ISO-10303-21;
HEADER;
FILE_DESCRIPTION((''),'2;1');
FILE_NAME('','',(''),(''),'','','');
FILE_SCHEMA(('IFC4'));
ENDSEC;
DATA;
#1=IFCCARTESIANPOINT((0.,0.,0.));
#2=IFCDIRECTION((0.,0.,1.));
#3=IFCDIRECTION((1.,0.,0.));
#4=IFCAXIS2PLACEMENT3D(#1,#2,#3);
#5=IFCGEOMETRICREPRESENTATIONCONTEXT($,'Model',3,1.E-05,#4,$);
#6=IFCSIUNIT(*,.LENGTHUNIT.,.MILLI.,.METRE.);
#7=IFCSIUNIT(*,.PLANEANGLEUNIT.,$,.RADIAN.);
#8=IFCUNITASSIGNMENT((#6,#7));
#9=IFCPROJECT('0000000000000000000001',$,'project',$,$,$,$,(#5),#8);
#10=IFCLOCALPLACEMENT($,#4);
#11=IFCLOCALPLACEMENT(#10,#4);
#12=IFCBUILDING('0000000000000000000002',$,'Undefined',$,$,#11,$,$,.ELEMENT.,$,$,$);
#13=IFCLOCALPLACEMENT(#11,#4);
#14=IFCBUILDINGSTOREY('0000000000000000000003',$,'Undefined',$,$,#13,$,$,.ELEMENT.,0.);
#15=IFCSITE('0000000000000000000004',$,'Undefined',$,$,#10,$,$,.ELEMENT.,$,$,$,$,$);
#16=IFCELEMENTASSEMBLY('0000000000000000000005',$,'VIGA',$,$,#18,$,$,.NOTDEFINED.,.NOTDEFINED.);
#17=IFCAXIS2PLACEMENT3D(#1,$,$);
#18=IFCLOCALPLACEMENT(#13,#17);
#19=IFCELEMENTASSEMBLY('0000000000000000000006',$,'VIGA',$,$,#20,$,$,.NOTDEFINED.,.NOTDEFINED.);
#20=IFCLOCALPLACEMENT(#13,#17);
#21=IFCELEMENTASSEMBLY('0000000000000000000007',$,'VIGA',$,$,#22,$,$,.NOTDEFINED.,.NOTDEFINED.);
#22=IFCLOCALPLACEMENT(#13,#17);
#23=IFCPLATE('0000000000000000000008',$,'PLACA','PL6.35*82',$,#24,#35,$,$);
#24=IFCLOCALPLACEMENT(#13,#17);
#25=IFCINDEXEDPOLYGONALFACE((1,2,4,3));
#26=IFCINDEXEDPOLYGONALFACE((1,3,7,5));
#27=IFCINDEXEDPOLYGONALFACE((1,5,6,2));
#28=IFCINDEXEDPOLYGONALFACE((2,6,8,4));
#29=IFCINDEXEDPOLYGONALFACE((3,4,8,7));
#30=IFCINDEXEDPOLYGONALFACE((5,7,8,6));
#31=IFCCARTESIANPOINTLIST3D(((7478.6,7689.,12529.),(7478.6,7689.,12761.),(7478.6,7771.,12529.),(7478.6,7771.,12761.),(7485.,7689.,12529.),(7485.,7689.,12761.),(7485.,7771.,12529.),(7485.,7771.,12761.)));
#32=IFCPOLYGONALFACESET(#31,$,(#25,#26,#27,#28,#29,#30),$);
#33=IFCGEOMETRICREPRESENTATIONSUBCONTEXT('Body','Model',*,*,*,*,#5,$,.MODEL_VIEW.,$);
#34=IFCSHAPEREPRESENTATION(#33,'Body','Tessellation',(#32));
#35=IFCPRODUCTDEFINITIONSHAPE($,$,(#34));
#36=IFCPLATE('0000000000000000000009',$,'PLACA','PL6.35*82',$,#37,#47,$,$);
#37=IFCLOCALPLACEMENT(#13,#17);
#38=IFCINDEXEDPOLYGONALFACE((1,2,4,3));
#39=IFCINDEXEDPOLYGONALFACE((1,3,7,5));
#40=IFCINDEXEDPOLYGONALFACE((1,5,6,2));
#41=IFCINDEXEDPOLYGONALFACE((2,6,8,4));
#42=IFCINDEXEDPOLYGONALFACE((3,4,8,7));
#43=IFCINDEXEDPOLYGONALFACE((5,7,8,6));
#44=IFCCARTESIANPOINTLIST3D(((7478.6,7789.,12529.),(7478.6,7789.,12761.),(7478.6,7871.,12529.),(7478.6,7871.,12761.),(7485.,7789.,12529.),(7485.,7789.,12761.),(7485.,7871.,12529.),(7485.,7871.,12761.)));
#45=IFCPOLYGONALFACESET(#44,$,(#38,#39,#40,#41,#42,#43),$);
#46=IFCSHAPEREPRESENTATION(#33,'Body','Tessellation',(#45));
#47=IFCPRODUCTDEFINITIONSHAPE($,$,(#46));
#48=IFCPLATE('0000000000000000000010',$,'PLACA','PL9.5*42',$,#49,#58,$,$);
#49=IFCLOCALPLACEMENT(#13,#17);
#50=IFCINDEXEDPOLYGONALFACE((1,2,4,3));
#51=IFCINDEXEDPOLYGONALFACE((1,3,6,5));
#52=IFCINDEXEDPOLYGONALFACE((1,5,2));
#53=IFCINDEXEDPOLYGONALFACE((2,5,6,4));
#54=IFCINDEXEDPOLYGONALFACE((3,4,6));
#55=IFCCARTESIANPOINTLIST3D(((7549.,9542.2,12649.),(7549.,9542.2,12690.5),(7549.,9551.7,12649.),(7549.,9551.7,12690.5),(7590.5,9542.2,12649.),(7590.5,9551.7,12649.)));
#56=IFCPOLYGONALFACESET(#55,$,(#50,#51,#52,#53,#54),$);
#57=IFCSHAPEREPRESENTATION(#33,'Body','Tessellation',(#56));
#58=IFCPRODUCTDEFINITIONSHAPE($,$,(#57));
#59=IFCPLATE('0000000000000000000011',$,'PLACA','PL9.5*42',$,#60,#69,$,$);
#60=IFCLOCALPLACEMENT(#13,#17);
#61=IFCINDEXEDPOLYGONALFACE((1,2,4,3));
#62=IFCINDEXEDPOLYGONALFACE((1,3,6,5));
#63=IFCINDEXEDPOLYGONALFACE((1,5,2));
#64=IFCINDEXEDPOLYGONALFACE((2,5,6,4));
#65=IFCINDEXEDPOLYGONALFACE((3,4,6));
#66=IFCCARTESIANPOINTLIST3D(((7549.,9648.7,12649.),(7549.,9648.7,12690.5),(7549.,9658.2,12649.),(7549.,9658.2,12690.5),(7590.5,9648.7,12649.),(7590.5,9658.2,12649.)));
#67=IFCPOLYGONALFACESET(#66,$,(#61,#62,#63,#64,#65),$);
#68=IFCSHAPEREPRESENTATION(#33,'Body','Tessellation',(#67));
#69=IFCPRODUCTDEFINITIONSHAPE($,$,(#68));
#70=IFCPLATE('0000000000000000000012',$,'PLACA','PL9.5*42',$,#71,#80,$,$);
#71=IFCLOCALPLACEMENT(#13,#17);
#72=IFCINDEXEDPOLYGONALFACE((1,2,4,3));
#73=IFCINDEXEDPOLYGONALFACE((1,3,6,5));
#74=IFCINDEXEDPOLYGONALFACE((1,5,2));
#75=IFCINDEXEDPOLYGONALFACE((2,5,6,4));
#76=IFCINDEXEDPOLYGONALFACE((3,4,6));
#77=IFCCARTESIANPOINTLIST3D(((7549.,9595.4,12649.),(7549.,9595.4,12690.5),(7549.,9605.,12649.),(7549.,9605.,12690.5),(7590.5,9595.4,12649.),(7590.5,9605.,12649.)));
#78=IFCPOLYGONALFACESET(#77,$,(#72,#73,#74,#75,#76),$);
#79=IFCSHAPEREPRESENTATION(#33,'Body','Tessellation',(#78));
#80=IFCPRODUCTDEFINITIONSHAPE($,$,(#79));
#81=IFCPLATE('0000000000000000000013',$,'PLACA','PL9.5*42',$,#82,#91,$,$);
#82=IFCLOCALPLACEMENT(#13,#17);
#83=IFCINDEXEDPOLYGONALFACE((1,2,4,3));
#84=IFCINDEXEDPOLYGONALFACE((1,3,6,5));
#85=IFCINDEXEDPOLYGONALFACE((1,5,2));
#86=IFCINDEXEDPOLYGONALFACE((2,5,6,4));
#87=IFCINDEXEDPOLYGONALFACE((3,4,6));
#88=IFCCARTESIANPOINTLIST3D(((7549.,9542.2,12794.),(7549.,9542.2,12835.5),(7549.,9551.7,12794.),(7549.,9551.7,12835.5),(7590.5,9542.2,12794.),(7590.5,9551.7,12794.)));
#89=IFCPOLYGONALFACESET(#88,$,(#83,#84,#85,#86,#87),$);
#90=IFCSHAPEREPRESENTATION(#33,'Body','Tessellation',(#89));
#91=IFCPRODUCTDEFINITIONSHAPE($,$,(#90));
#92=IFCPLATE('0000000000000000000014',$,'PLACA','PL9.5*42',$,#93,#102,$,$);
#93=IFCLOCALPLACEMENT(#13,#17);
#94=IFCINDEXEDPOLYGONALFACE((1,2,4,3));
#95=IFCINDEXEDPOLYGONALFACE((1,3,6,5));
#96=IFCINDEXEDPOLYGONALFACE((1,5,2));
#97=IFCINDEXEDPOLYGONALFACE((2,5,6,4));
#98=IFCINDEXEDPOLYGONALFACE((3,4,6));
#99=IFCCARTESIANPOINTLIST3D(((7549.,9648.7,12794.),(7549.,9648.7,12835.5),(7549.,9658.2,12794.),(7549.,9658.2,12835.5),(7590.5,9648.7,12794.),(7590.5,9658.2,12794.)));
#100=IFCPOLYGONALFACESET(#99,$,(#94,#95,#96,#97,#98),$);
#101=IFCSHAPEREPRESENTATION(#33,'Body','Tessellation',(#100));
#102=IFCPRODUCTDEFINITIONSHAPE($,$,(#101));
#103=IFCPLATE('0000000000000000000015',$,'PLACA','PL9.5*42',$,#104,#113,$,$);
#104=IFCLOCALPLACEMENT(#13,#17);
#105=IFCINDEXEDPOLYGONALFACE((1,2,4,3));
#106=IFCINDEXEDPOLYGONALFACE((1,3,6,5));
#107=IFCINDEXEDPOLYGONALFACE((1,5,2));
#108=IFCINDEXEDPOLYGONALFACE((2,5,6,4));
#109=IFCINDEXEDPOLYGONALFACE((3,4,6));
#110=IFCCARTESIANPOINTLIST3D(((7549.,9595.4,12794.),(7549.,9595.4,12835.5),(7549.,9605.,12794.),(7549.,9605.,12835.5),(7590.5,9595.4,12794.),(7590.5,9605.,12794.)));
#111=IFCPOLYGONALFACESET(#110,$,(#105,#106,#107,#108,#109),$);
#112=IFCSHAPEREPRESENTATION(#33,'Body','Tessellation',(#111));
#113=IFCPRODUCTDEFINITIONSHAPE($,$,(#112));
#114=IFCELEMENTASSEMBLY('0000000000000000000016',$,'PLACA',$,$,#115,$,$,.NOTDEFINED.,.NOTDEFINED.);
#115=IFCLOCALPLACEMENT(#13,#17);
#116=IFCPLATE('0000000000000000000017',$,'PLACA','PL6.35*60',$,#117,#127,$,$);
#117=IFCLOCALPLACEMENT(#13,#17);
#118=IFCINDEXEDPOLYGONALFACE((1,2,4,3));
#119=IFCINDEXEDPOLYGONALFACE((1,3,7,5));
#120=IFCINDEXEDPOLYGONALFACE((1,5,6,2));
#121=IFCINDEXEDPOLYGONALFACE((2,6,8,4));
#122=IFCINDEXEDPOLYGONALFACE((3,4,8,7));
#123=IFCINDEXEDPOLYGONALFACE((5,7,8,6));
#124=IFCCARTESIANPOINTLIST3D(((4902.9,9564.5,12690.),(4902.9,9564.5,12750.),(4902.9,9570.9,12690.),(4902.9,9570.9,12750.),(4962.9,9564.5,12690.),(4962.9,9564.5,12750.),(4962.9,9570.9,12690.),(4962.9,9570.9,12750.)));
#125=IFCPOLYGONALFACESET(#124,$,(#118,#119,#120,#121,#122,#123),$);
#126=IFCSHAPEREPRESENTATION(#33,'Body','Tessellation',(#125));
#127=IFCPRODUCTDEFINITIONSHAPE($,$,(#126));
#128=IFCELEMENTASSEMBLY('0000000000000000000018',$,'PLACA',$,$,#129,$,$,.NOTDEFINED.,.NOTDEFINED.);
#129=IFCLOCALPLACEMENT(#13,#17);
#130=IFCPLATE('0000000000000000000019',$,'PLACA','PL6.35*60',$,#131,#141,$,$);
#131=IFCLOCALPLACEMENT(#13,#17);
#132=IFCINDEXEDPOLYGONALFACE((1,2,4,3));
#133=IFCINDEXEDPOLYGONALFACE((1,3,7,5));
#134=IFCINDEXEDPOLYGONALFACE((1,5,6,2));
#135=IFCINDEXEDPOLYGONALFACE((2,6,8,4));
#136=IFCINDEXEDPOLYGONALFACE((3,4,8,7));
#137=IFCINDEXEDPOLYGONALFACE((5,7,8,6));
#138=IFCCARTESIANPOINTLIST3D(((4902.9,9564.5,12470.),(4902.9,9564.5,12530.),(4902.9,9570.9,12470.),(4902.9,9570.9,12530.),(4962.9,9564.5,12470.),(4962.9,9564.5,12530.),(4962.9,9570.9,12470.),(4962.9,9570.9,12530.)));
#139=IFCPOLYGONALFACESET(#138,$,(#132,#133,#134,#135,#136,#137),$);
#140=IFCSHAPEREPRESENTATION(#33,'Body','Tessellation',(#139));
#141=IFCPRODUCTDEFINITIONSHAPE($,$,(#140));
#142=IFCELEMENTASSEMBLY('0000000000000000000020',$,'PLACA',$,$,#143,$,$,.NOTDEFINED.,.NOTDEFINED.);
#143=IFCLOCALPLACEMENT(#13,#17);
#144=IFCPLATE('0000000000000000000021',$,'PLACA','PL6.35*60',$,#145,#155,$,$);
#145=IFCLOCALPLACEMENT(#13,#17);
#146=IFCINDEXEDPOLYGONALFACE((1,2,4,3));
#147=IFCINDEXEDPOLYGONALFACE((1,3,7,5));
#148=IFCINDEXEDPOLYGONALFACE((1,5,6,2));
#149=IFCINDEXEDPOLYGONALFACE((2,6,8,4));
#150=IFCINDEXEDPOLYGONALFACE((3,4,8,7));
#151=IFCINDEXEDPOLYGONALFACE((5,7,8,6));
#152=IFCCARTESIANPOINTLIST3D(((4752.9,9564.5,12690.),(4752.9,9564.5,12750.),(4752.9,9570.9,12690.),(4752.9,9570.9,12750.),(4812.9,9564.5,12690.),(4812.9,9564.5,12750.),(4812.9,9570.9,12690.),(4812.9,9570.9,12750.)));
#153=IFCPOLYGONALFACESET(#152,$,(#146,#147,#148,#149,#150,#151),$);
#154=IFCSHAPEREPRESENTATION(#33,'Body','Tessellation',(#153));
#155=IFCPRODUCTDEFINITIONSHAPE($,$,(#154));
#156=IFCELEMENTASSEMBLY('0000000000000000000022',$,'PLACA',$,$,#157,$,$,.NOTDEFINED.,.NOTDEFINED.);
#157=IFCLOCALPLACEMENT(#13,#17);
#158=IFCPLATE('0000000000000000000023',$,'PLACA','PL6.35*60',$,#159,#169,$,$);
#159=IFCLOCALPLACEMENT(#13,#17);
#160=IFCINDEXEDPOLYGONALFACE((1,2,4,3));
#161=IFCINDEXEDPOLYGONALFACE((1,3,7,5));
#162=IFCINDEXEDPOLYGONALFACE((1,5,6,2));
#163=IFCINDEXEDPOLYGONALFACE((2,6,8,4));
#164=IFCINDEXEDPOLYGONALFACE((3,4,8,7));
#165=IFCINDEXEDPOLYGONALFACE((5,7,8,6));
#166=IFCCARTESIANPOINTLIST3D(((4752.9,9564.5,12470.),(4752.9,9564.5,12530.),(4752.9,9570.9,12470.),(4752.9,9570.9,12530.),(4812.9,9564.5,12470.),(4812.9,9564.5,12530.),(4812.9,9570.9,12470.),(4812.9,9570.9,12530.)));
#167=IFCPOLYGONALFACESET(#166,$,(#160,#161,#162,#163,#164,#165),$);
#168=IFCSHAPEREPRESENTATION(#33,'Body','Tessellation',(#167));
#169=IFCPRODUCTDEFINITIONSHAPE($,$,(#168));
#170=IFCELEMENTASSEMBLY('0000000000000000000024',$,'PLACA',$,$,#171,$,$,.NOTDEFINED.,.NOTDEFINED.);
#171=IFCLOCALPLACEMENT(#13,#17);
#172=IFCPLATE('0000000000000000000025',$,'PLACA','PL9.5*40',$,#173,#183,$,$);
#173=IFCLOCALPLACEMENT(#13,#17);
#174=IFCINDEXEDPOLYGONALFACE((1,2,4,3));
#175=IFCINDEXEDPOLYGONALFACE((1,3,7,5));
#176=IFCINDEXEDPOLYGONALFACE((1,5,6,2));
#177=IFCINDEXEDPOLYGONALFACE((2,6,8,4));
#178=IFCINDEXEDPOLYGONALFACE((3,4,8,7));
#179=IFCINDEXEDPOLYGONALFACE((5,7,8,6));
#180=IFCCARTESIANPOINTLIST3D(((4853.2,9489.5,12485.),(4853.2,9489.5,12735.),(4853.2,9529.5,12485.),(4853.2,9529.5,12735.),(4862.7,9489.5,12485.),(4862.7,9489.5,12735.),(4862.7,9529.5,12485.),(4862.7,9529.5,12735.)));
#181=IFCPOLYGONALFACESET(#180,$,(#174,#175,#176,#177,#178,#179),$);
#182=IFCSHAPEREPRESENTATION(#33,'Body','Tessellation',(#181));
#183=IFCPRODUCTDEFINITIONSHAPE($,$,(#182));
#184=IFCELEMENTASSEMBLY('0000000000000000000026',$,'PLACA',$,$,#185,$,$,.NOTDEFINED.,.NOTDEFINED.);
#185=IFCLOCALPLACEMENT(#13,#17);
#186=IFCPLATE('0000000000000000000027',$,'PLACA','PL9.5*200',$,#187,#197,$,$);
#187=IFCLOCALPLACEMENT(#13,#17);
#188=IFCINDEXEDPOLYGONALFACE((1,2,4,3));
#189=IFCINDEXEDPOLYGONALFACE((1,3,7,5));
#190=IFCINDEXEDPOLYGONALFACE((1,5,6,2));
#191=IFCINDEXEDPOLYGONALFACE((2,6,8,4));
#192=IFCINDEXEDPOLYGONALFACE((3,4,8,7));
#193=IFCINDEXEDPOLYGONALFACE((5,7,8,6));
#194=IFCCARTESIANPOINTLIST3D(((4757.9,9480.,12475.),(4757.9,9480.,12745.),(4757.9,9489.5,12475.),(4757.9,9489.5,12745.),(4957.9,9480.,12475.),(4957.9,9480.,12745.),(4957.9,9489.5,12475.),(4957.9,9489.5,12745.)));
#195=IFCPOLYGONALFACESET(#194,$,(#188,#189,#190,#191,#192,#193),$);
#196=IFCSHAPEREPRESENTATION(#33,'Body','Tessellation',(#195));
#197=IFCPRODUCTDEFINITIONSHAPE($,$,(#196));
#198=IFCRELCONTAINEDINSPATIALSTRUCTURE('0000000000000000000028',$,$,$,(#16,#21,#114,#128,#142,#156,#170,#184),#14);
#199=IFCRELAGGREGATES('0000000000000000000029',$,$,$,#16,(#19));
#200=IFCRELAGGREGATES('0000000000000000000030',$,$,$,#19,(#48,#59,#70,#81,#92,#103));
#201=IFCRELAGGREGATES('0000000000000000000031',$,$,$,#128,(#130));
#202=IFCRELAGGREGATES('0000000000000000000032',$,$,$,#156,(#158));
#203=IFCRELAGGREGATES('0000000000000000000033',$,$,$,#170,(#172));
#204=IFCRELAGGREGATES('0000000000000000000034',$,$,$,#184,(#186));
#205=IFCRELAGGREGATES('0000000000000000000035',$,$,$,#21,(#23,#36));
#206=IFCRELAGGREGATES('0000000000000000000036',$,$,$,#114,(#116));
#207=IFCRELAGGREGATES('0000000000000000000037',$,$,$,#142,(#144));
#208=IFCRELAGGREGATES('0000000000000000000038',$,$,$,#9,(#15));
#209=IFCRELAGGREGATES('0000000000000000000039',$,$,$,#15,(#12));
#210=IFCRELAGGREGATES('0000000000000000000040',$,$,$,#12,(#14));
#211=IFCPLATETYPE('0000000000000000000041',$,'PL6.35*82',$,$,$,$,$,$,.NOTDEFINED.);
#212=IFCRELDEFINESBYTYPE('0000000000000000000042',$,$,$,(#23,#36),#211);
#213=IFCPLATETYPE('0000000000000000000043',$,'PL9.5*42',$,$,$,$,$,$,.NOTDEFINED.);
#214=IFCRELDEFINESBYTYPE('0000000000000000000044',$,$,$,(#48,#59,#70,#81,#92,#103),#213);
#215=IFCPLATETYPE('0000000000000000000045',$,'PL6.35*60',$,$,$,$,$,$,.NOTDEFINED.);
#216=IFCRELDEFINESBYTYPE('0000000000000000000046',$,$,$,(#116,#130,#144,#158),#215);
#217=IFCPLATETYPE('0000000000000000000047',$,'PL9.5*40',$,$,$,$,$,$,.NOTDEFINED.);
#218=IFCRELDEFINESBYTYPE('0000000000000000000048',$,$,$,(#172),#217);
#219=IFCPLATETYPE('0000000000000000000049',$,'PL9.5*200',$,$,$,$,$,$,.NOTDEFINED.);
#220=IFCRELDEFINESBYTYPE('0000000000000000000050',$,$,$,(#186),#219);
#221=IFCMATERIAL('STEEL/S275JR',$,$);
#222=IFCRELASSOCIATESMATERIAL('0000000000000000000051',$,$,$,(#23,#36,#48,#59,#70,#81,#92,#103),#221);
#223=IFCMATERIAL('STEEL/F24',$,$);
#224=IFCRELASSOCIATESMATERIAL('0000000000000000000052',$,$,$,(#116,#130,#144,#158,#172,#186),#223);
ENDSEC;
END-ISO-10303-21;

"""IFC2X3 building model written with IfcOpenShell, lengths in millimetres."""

from ifc_helpers import new_model, si_unit, frame, origin_with_axes, place, context, subcontext, project, spatial, polyline, outline, extrude, material, type_object, element, aggregate, save


model = new_model("IFC2X3")

# Units and contexts
model_context = context("Model", 3, precision=1e-05, world=origin_with_axes())
body_context = subcontext(model_context, "Body", "Model", "MODEL_VIEW")
ifc_project = project(units=[si_unit("LENGTHUNIT", "METRE", prefix="MILLI"), si_unit("PLANEANGLEUNIT", "RADIAN")], contexts=[model_context])

# Site, building, storey
site_placement = place(None, origin_with_axes())
site = spatial("IfcSite", under=ifc_project, at=site_placement, Name="Undefined", CompositionType="ELEMENT")
building_placement = place(site_placement, origin_with_axes())
building = spatial("IfcBuilding", under=site, at=building_placement, Name="Undefined", CompositionType="ELEMENT")
storey_placement = place(building_placement, origin_with_axes())
storey = spatial("IfcBuildingStorey", under=building, at=storey_placement, Name="Undefined", CompositionType="ELEMENT", Elevation=0.0)

# Shared definitions
ifc_material_1 = material(Name="STEEL/S275JR")

# Element assemblies
assembly_1_placement = place(storey_placement, origin_with_axes())
assembly_1 = element("IfcElementAssembly", 1, at=assembly_1_placement, inside=storey, Name="VIGA", AssemblyPlace="NOTDEFINED", PredefinedType="NOTDEFINED")
assembly_2_placement = place(assembly_1_placement, origin_with_axes())
assembly_2 = element("IfcElementAssembly", 2, at=assembly_2_placement, Name="VIGA", AssemblyPlace="NOTDEFINED", PredefinedType="NOTDEFINED")
aggregate(assembly_1, [assembly_2])

# Element assembly, plates
assembly_3_placement = place(storey_placement, origin_with_axes())
assembly_3 = element("IfcElementAssembly", 3, at=assembly_3_placement, inside=storey, Name="VIGA", AssemblyPlace="NOTDEFINED", PredefinedType="NOTDEFINED")
plate_type_1 = type_object("IfcPlateType", Name="PL6.35*82", PredefinedType="NOTDEFINED")
plate_1_placement = place(assembly_3_placement, frame((7481.8, 7689.0, 12761.0), z_axis=(-1.0, 0.0, 0.0), x_axis=(0.0, 1.0, 0.0)))
plate_1 = element("IfcPlate", 4, at=plate_1_placement, type_object=plate_type_1, material=ifc_material_1, Name="PLACA", Description="PL6.35*82", context=body_context, shape_type="SweptSolid", body=[
    extrude(outline(polyline([(0.0, 0.0), (82.0, 0.0), (82.0, 232.0), (0.0, 232.0), (0.0, 0.0)])), frame((0.0, 0.0, -3.2), z_axis=(0.0, 0.0, 1.0), x_axis=(1.0, 0.0, 0.0)), (0.0, 0.0, 1.0), 6.4),
])
plate_2_placement = place(assembly_3_placement, frame((7481.8, 7789.0, 12761.0), z_axis=(-1.0, 0.0, 0.0), x_axis=(0.0, 1.0, 0.0)))
plate_2 = element("IfcPlate", 5, at=plate_2_placement, type_object=plate_type_1, material=ifc_material_1, Name="PLACA", Description="PL6.35*82", context=body_context, shape_type="SweptSolid", body=[
    extrude(outline(polyline([(0.0, 0.0), (82.0, 0.0), (82.0, 232.0), (0.0, 232.0), (0.0, 0.0)])), frame((0.0, 0.0, -3.2), z_axis=(0.0, 0.0, 1.0), x_axis=(1.0, 0.0, 0.0)), (0.0, 0.0, 1.0), 6.4),
])

# Plates
plate_type_2 = type_object("IfcPlateType", Name="PL9.5*42", PredefinedType="NOTDEFINED")
plate_3_placement = place(assembly_2_placement, frame((7549.0, 9547.0, 12649.0), z_axis=(0.0, 1.0, 0.0), x_axis=(0.0, 0.0, 1.0)))
plate_3 = element("IfcPlate", 6, at=plate_3_placement, type_object=plate_type_2, material=ifc_material_1, Name="PLACA", Description="PL9.5*42", context=body_context, shape_type="SweptSolid", body=[
    extrude(outline(polyline([(0.0, 0.0), (41.5, 0.0), (0.0, 41.5), (0.0, 0.0)])), frame((0.0, 0.0, -4.7), z_axis=(0.0, 0.0, 1.0), x_axis=(1.0, 0.0, 0.0)), (0.0, 0.0, 1.0), 9.5),
])
plate_4_placement = place(assembly_2_placement, frame((7549.0, 9653.5, 12649.0), z_axis=(0.0, 1.0, 0.0), x_axis=(0.0, 0.0, 1.0)))
plate_4 = element("IfcPlate", 7, at=plate_4_placement, type_object=plate_type_2, material=ifc_material_1, Name="PLACA", Description="PL9.5*42", context=body_context, shape_type="SweptSolid", body=[
    extrude(outline(polyline([(0.0, 0.0), (41.5, 0.0), (0.0, 41.5), (0.0, 0.0)])), frame((0.0, 0.0, -4.7), z_axis=(0.0, 0.0, 1.0), x_axis=(1.0, 0.0, 0.0)), (0.0, 0.0, 1.0), 9.5),
])
plate_5_placement = place(assembly_2_placement, frame((7549.0, 9600.2, 12649.0), z_axis=(0.0, 1.0, 0.0), x_axis=(0.0, 0.0, 1.0)))
plate_5 = element("IfcPlate", 8, at=plate_5_placement, type_object=plate_type_2, material=ifc_material_1, Name="PLACA", Description="PL9.5*42", context=body_context, shape_type="SweptSolid", body=[
    extrude(outline(polyline([(0.0, 0.0), (41.5, 0.0), (0.0, 41.5), (0.0, 0.0)])), frame((0.0, 0.0, -4.7), z_axis=(0.0, 0.0, 1.0), x_axis=(1.0, 0.0, 0.0)), (0.0, 0.0, 1.0), 9.5),
])
plate_6_placement = place(assembly_2_placement, frame((7549.0, 9547.0, 12794.0), z_axis=(0.0, 1.0, 0.0), x_axis=(0.0, 0.0, 1.0)))
plate_6 = element("IfcPlate", 9, at=plate_6_placement, type_object=plate_type_2, material=ifc_material_1, Name="PLACA", Description="PL9.5*42", context=body_context, shape_type="SweptSolid", body=[
    extrude(outline(polyline([(0.0, 0.0), (41.5, 0.0), (0.0, 41.5), (0.0, 0.0)])), frame((0.0, 0.0, -4.7), z_axis=(0.0, 0.0, 1.0), x_axis=(1.0, 0.0, 0.0)), (0.0, 0.0, 1.0), 9.5),
])
plate_7_placement = place(assembly_2_placement, frame((7549.0, 9653.5, 12794.0), z_axis=(0.0, 1.0, 0.0), x_axis=(0.0, 0.0, 1.0)))
plate_7 = element("IfcPlate", 10, at=plate_7_placement, type_object=plate_type_2, material=ifc_material_1, Name="PLACA", Description="PL9.5*42", context=body_context, shape_type="SweptSolid", body=[
    extrude(outline(polyline([(0.0, 0.0), (41.5, 0.0), (0.0, 41.5), (0.0, 0.0)])), frame((0.0, 0.0, -4.7), z_axis=(0.0, 0.0, 1.0), x_axis=(1.0, 0.0, 0.0)), (0.0, 0.0, 1.0), 9.5),
])
plate_8_placement = place(assembly_2_placement, frame((7549.0, 9600.2, 12794.0), z_axis=(0.0, 1.0, 0.0), x_axis=(0.0, 0.0, 1.0)))
plate_8 = element("IfcPlate", 11, at=plate_8_placement, type_object=plate_type_2, material=ifc_material_1, Name="PLACA", Description="PL9.5*42", context=body_context, shape_type="SweptSolid", body=[
    extrude(outline(polyline([(0.0, 0.0), (41.5, 0.0), (0.0, 41.5), (0.0, 0.0)])), frame((0.0, 0.0, -4.7), z_axis=(0.0, 0.0, 1.0), x_axis=(1.0, 0.0, 0.0)), (0.0, 0.0, 1.0), 9.5),
])
aggregate(assembly_2, [plate_3, plate_4, plate_5, plate_6, plate_7, plate_8])

# Element assemblies, plates
assembly_4_placement = place(storey_placement, origin_with_axes())
assembly_4 = element("IfcElementAssembly", 12, at=assembly_4_placement, inside=storey, Name="PLACA", AssemblyPlace="NOTDEFINED", PredefinedType="NOTDEFINED")
ifc_material_2 = material(Name="STEEL/F24")
plate_type_3 = type_object("IfcPlateType", Name="PL6.35*60", PredefinedType="NOTDEFINED")
plate_9_placement = place(assembly_4_placement, frame((4902.9, 9567.7, 12750.0), z_axis=(0.0, 1.0, 0.0), x_axis=(1.0, 0.0, 0.0)))
plate_9 = element("IfcPlate", 13, at=plate_9_placement, type_object=plate_type_3, material=ifc_material_2, Name="PLACA", Description="PL6.35*60", context=body_context, shape_type="SweptSolid", body=[
    extrude(outline(polyline([(0.0, 0.0), (60.0, 0.0), (60.0, 60.0), (0.0, 60.0), (0.0, 0.0)])), frame((0.0, 0.0, -3.2), z_axis=(0.0, 0.0, 1.0), x_axis=(1.0, 0.0, 0.0)), (0.0, 0.0, 1.0), 6.4),
])
assembly_5_placement = place(storey_placement, origin_with_axes())
assembly_5 = element("IfcElementAssembly", 14, at=assembly_5_placement, inside=storey, Name="PLACA", AssemblyPlace="NOTDEFINED", PredefinedType="NOTDEFINED")
plate_10_placement = place(assembly_5_placement, frame((4902.9, 9567.7, 12530.0), z_axis=(0.0, 1.0, 0.0), x_axis=(1.0, 0.0, 0.0)))
plate_10 = element("IfcPlate", 15, at=plate_10_placement, type_object=plate_type_3, material=ifc_material_2, Name="PLACA", Description="PL6.35*60", context=body_context, shape_type="SweptSolid", body=[
    extrude(outline(polyline([(0.0, 0.0), (60.0, 0.0), (60.0, 60.0), (0.0, 60.0), (0.0, 0.0)])), frame((0.0, 0.0, -3.2), z_axis=(0.0, 0.0, 1.0), x_axis=(1.0, 0.0, 0.0)), (0.0, 0.0, 1.0), 6.4),
])
aggregate(assembly_5, [plate_10])
assembly_6_placement = place(storey_placement, origin_with_axes())
assembly_6 = element("IfcElementAssembly", 16, at=assembly_6_placement, inside=storey, Name="PLACA", AssemblyPlace="NOTDEFINED", PredefinedType="NOTDEFINED")
plate_11_placement = place(assembly_6_placement, frame((4752.9, 9567.7, 12750.0), z_axis=(0.0, 1.0, 0.0), x_axis=(1.0, 0.0, 0.0)))
plate_11 = element("IfcPlate", 17, at=plate_11_placement, type_object=plate_type_3, material=ifc_material_2, Name="PLACA", Description="PL6.35*60", context=body_context, shape_type="SweptSolid", body=[
    extrude(outline(polyline([(0.0, 0.0), (60.0, 0.0), (60.0, 60.0), (0.0, 60.0), (0.0, 0.0)])), frame((0.0, 0.0, -3.2), z_axis=(0.0, 0.0, 1.0), x_axis=(1.0, 0.0, 0.0)), (0.0, 0.0, 1.0), 6.4),
])
assembly_7_placement = place(storey_placement, origin_with_axes())
assembly_7 = element("IfcElementAssembly", 18, at=assembly_7_placement, inside=storey, Name="PLACA", AssemblyPlace="NOTDEFINED", PredefinedType="NOTDEFINED")
plate_12_placement = place(assembly_7_placement, frame((4752.9, 9567.7, 12530.0), z_axis=(0.0, 1.0, 0.0), x_axis=(1.0, 0.0, 0.0)))
plate_12 = element("IfcPlate", 19, at=plate_12_placement, type_object=plate_type_3, material=ifc_material_2, Name="PLACA", Description="PL6.35*60", context=body_context, shape_type="SweptSolid", body=[
    extrude(outline(polyline([(0.0, 0.0), (60.0, 0.0), (60.0, 60.0), (0.0, 60.0), (0.0, 0.0)])), frame((0.0, 0.0, -3.2), z_axis=(0.0, 0.0, 1.0), x_axis=(1.0, 0.0, 0.0)), (0.0, 0.0, 1.0), 6.4),
])
aggregate(assembly_7, [plate_12])
assembly_8_placement = place(storey_placement, origin_with_axes())
assembly_8 = element("IfcElementAssembly", 20, at=assembly_8_placement, inside=storey, Name="PLACA", AssemblyPlace="NOTDEFINED", PredefinedType="NOTDEFINED")
plate_type_4 = type_object("IfcPlateType", Name="PL9.5*40", PredefinedType="NOTDEFINED")
plate_13_placement = place(assembly_8_placement, frame((4857.9, 9489.5, 12735.0), z_axis=(1.0, 0.0, 0.0), x_axis=(0.0, 0.0, -1.0)))
plate_13 = element("IfcPlate", 21, at=plate_13_placement, type_object=plate_type_4, material=ifc_material_2, Name="PLACA", Description="PL9.5*40", context=body_context, shape_type="SweptSolid", body=[
    extrude(outline(polyline([(0.0, 0.0), (250.0, 0.0), (250.0, 40.0), (0.0, 40.0), (0.0, 0.0)])), frame((0.0, 0.0, -4.7), z_axis=(0.0, 0.0, 1.0), x_axis=(1.0, 0.0, 0.0)), (0.0, 0.0, 1.0), 9.5),
])
aggregate(assembly_8, [plate_13])
assembly_9_placement = place(storey_placement, origin_with_axes())
assembly_9 = element("IfcElementAssembly", 22, at=assembly_9_placement, inside=storey, Name="PLACA", AssemblyPlace="NOTDEFINED", PredefinedType="NOTDEFINED")
plate_type_5 = type_object("IfcPlateType", Name="PL9.5*200", PredefinedType="NOTDEFINED")
plate_14_placement = place(assembly_9_placement, frame((4757.9, 9484.8, 12745.0), z_axis=(0.0, 1.0, 0.0), x_axis=(1.0, 0.0, 0.0)))
plate_14 = element("IfcPlate", 23, at=plate_14_placement, type_object=plate_type_5, material=ifc_material_2, Name="PLACA", Description="PL9.5*200", context=body_context, shape_type="SweptSolid", body=[
    extrude(outline(polyline([(0.0, 0.0), (200.0, 0.0), (200.0, 270.0), (0.0, 270.0), (0.0, 0.0)])), frame((0.0, 0.0, -4.7), z_axis=(0.0, 0.0, 1.0), x_axis=(1.0, 0.0, 0.0)), (0.0, 0.0, 1.0), 9.5),
])
aggregate(assembly_9, [plate_14])

aggregate(assembly_3, [plate_1, plate_2])

aggregate(assembly_4, [plate_9])
aggregate(assembly_6, [plate_11])

save(model, "model.ifc")
